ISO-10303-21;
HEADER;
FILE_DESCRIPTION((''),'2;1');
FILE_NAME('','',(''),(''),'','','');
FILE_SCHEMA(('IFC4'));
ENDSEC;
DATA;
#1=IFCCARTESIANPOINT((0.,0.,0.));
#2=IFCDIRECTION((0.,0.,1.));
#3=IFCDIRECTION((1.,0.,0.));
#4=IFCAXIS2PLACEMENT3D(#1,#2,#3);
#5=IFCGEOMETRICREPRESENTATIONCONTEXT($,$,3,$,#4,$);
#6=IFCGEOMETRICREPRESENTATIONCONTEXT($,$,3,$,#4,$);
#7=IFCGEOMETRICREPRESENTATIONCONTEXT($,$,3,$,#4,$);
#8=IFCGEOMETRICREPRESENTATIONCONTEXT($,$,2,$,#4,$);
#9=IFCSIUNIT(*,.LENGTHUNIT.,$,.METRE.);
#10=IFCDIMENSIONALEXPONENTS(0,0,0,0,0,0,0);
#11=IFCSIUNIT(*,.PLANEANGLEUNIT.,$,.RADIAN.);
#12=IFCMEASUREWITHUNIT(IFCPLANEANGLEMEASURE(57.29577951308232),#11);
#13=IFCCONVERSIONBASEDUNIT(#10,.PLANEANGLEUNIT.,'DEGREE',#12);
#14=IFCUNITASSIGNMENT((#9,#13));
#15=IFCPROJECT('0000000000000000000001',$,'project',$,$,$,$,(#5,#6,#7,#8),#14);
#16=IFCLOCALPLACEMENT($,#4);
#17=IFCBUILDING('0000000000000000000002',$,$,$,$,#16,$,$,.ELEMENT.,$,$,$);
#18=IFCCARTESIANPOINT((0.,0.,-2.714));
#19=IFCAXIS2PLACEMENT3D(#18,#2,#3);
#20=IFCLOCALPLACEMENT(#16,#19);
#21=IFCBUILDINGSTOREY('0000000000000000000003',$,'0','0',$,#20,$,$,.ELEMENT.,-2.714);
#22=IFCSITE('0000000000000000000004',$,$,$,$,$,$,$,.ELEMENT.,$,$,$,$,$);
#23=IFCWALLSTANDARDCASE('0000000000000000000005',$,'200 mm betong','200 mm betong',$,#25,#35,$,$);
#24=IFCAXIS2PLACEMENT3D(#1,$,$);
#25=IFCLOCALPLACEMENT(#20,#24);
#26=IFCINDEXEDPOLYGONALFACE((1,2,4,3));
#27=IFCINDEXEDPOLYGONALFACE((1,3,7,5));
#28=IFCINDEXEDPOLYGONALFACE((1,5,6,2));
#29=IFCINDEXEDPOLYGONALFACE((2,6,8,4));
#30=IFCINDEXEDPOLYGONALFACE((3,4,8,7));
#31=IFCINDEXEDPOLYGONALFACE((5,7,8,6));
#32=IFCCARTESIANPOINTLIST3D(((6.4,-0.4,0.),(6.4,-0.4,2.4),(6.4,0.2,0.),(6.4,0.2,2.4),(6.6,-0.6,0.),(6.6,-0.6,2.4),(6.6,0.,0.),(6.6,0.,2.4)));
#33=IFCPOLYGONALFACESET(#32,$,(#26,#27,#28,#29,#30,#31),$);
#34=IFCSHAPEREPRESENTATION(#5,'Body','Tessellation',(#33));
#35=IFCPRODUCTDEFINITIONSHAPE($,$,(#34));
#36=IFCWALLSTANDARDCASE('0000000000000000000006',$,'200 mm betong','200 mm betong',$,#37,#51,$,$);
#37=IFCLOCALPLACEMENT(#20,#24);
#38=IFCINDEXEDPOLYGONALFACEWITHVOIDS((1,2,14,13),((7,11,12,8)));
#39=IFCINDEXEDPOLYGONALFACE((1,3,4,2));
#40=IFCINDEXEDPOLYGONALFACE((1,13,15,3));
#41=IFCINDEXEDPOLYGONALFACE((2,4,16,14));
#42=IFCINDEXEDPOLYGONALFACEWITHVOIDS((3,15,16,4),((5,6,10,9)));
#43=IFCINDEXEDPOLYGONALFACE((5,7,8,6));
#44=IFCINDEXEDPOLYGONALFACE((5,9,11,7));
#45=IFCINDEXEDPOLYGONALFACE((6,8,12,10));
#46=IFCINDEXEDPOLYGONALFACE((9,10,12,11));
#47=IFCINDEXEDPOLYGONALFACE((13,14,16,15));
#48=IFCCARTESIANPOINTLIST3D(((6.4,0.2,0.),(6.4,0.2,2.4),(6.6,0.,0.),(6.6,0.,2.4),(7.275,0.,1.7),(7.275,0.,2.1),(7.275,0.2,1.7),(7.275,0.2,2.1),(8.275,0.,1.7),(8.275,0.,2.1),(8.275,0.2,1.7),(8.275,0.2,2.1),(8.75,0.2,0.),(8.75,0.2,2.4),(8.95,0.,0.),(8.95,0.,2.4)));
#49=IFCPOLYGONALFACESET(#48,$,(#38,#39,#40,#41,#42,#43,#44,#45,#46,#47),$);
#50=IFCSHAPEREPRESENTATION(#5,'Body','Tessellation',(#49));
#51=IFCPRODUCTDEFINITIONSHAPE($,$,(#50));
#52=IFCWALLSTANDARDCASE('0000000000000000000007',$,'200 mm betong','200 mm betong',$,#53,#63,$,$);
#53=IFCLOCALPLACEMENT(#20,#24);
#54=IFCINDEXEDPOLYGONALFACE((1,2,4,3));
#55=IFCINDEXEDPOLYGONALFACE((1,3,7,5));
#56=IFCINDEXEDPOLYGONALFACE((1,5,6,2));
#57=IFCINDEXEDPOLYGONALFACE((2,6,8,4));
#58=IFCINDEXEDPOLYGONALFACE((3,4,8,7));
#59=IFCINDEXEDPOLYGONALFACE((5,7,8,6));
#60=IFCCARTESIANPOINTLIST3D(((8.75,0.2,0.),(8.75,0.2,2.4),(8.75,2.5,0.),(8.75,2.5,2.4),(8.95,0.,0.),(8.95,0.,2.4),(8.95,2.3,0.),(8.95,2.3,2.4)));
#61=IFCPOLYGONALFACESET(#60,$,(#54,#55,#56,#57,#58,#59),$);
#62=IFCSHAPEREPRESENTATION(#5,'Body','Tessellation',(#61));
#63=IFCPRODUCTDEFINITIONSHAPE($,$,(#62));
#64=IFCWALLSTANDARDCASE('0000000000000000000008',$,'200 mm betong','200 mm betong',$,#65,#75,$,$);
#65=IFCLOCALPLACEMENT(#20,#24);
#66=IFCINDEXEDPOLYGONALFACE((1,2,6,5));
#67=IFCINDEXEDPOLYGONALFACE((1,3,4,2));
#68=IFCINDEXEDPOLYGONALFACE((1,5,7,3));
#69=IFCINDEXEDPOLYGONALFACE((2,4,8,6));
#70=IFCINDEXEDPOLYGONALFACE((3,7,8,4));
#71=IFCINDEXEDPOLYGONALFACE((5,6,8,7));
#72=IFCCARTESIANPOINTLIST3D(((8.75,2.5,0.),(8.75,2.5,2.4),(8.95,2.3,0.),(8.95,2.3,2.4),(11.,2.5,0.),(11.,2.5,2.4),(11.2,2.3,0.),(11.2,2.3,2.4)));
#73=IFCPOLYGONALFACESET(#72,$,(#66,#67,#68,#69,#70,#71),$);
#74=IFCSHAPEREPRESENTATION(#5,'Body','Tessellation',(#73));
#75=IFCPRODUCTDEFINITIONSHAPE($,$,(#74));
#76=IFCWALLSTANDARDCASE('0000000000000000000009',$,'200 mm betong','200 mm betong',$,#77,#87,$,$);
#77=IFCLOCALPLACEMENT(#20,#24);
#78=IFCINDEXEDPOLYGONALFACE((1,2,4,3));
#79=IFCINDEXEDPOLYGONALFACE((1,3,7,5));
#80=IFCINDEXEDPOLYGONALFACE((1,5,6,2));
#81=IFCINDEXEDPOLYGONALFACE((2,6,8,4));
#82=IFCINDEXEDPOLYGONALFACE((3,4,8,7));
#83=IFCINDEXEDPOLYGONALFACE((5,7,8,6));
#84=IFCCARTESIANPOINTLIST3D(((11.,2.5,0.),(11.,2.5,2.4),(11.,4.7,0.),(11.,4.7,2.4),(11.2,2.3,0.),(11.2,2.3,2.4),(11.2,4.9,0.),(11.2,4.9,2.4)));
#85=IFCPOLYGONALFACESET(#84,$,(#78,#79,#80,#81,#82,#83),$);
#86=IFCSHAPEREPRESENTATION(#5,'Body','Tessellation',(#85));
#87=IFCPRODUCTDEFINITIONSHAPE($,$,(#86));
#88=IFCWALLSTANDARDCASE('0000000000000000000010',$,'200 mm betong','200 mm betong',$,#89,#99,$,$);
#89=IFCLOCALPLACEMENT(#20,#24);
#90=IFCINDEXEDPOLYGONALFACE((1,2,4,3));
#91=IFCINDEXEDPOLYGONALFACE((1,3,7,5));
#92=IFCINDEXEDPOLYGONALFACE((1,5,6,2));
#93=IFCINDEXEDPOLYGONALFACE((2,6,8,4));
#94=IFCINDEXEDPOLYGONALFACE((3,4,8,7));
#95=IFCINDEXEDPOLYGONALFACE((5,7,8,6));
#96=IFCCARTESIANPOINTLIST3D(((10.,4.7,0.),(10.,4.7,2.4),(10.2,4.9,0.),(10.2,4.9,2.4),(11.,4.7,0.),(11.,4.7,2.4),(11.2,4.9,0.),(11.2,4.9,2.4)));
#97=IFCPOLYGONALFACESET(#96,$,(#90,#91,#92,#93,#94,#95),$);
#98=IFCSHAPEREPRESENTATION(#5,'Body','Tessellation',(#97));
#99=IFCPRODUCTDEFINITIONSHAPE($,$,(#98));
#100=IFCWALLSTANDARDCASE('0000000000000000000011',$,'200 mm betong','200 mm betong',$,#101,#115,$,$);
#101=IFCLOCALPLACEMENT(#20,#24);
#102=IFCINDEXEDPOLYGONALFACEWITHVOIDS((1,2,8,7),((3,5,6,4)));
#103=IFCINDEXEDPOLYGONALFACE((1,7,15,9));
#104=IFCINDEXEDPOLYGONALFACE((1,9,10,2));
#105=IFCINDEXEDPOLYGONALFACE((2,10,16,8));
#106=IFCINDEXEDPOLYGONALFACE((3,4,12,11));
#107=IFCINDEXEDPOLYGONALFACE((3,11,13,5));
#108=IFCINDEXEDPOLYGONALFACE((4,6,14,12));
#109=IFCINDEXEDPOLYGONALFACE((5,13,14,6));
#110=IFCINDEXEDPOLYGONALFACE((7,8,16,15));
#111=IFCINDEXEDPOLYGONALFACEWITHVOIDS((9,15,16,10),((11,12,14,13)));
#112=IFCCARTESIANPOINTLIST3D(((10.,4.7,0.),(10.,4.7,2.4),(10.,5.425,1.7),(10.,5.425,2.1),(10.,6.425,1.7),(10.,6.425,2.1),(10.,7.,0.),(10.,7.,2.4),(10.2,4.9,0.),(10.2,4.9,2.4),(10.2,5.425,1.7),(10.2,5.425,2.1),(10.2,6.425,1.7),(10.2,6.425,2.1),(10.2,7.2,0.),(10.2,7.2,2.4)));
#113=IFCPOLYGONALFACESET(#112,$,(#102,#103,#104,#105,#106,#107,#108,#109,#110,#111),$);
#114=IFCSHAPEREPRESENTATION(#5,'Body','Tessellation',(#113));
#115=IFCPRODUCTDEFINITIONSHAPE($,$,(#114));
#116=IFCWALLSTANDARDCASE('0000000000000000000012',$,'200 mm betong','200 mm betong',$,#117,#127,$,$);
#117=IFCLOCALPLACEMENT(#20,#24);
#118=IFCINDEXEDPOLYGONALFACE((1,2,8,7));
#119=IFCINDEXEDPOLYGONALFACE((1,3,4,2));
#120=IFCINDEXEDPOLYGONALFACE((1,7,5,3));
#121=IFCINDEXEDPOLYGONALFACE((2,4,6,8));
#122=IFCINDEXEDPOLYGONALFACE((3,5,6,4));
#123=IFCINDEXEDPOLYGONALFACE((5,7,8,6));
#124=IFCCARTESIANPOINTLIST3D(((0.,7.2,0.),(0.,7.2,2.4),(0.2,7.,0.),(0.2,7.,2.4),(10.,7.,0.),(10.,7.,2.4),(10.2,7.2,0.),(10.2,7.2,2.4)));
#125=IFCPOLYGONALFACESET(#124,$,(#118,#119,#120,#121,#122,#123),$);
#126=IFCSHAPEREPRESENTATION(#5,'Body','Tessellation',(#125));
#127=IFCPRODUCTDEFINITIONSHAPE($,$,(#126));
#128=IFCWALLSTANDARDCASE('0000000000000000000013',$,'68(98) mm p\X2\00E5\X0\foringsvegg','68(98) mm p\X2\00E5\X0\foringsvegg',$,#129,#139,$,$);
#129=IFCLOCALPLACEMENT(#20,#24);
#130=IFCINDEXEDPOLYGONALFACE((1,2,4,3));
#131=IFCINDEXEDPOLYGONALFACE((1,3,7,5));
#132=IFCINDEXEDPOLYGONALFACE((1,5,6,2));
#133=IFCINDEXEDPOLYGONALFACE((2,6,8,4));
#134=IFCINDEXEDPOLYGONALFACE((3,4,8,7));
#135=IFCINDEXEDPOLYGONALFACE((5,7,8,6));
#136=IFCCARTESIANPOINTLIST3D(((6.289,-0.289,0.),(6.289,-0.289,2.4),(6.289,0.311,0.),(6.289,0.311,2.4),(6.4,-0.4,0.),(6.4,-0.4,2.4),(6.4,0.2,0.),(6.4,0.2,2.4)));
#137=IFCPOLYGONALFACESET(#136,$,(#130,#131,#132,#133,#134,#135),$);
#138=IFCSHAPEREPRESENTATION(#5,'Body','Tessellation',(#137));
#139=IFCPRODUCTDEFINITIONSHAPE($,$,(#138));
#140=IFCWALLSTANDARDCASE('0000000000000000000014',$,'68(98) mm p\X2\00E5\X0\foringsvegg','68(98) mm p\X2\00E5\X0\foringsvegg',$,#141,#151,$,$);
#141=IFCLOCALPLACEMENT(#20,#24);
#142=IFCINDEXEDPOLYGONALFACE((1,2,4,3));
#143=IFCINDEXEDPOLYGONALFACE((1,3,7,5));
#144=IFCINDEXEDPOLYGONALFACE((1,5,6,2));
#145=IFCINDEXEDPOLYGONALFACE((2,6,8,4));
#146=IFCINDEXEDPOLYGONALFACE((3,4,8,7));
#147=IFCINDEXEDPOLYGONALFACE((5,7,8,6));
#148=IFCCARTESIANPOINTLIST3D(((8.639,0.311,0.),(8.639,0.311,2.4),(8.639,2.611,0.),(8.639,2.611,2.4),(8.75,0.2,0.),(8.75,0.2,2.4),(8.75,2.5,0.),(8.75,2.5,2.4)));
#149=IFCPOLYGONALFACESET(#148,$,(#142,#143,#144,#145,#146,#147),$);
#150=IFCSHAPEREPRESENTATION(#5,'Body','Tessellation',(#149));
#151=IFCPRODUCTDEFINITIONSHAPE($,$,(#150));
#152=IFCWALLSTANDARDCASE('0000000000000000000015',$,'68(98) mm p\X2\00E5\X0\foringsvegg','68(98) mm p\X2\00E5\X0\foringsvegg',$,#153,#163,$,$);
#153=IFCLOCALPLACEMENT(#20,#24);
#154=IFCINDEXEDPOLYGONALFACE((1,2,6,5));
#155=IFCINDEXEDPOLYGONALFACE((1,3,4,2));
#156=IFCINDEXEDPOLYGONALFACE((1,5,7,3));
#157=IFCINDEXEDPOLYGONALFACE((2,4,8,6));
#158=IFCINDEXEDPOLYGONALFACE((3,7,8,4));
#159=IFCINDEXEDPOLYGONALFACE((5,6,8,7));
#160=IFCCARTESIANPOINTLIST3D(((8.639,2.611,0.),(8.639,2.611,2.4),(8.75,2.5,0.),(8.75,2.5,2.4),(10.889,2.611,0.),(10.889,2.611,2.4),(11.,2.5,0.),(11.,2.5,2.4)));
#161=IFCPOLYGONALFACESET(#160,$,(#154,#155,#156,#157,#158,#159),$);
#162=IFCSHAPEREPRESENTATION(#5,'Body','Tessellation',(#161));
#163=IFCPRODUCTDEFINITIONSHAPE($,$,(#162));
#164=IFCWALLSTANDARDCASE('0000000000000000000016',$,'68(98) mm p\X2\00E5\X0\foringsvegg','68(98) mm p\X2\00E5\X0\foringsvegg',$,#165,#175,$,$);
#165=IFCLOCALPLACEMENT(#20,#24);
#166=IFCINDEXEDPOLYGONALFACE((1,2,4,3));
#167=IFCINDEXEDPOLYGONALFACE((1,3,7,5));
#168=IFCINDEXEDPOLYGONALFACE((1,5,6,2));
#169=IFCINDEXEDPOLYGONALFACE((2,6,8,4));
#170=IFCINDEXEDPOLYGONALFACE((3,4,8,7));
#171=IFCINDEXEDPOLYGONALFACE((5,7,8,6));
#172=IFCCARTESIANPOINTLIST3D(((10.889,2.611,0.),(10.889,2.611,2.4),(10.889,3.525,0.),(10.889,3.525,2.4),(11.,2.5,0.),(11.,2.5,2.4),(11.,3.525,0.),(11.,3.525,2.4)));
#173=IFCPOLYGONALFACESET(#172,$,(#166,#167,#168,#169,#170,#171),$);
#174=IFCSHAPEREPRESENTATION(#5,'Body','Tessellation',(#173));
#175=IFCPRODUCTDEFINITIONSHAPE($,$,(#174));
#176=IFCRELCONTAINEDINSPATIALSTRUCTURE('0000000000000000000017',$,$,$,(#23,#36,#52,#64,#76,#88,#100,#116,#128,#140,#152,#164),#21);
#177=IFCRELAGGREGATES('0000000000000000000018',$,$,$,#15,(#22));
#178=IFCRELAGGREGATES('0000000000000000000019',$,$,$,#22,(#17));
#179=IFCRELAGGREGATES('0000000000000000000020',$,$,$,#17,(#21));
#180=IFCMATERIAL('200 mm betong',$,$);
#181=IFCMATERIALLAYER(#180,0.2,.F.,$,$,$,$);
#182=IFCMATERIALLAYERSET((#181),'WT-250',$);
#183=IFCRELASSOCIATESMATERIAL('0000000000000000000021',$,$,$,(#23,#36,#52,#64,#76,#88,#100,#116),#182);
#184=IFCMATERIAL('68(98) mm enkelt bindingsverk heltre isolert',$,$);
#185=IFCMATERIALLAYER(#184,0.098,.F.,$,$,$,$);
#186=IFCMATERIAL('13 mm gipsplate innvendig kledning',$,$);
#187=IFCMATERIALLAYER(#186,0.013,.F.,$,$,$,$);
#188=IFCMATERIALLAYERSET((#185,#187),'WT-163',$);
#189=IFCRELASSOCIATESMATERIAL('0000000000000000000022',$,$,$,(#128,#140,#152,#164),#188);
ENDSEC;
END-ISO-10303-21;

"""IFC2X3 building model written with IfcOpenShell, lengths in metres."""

from ifc_helpers import new_model, entity, si_unit, converted_unit, frame, origin_with_axes, place, context, project, spatial, polyline, outline, extrude, material, layer, layer_set, layer_usage, element, save


model = new_model("IFC2X3")

# Units and contexts
context_of_model_1 = context(None, 3, world=origin_with_axes())
context_of_model_2 = context(None, 3, world=origin_with_axes())
context_of_model_3 = context(None, 3, world=origin_with_axes())
context_of_model_4 = context(None, 2, world=origin_with_axes())
ifc_project = project(units=[si_unit("LENGTHUNIT", "METRE"), converted_unit("PLANEANGLEUNIT", "DEGREE", entity("IfcPlaneAngleMeasure", 57.29577951308232), si_unit("PLANEANGLEUNIT", "RADIAN"), dimensions=[0, 0, 0, 0, 0, 0, 0])], contexts=[context_of_model_1, context_of_model_2, context_of_model_3, context_of_model_4])

# Site, building, storey
site = spatial("IfcSite", under=ifc_project, CompositionType="ELEMENT")
building_placement = place(None, origin_with_axes())
building = spatial("IfcBuilding", under=site, at=building_placement, CompositionType="ELEMENT")
storey_placement = place(building_placement, frame((0.0, 0.0, -2.714), z_axis=(0.0, 0.0, 1.0), x_axis=(1.0, 0.0, 0.0)))
storey = spatial("IfcBuildingStorey", under=building, at=storey_placement, Name="0", Description="0", CompositionType="ELEMENT", Elevation=-2.714)

# Wall
ifc_material_1 = material(Name="200 mm betong")
ifc_layer_1 = layer(ifc_material_1, 0.2, ventilated=False)
ifc_layer_set_1 = layer_set([ifc_layer_1], Name="WT-250")
ifc_layer_usage_1 = layer_usage(ifc_layer_set_1, "AXIS2", "POSITIVE", 0.0)
wall_1_placement = place(storey_placement, frame((6.6, -0.6, 0.0), z_axis=(0.0, 0.0, 1.0), x_axis=(0.0, 1.0, 0.0)))
element("IfcWallStandardCase", 1, at=wall_1_placement, inside=storey, material=ifc_layer_usage_1, Name="200 mm betong", Description="200 mm betong", context=context_of_model_1, shape_type="SweptSolid", body=[
    extrude(outline(polyline([(0.0, 0.0), (0.6, 0.0), (0.8, 0.2), (0.2, 0.2), (0.0, 0.0)])), frame((0.0, 0.0, 0.0), z_axis=(0.0, 0.0, 1.0), x_axis=(1.0, 0.0, 0.0)), (0.0, 0.0, 1.0), 2.4),
])

# Wall, opening
wall_2_placement = place(storey_placement, frame((6.6, 0.0, 0.0), z_axis=(0.0, 0.0, 1.0), x_axis=(1.0, 0.0, 0.0)))
wall_2 = element("IfcWallStandardCase", 2, at=wall_2_placement, inside=storey, material=ifc_layer_usage_1, Name="200 mm betong", Description="200 mm betong", context=context_of_model_1, shape_type="SweptSolid", body=[
    extrude(outline(polyline([(0.0, 0.0), (2.35, 0.0), (2.15, 0.2), (-0.2, 0.2), (0.0, 0.0)])), frame((0.0, 0.0, 0.0), z_axis=(0.0, 0.0, 1.0), x_axis=(1.0, 0.0, 0.0)), (0.0, 0.0, 1.0), 2.4),
])
opening_1_placement = place(wall_2_placement, frame((0.675, 0.0, 1.7), z_axis=(0.0, 0.0, 1.0), x_axis=(1.0, 0.0, 0.0)))
element("IfcOpeningElement", 3, at=opening_1_placement, inside=storey, cuts=wall_2, context=context_of_model_1, shape_type="SweptSolid", body=[
    extrude(outline(polyline([(0.0, 0.0), (0.4, 0.0), (0.4, 1.0), (0.0, 1.0), (0.0, 0.0)])), frame((0.0, 0.0, 0.0), z_axis=(0.0, 1.0, 0.0), x_axis=(0.0, 0.0, 1.0)), (0.0, 0.0, 1.0), 0.2),
])

# Walls
wall_3_placement = place(storey_placement, frame((8.95, 0.0, 0.0), z_axis=(0.0, 0.0, 1.0), x_axis=(0.0, 1.0, 0.0)))
element("IfcWallStandardCase", 4, at=wall_3_placement, inside=storey, material=ifc_layer_usage_1, Name="200 mm betong", Description="200 mm betong", context=context_of_model_1, shape_type="SweptSolid", body=[
    extrude(outline(polyline([(0.0, 0.0), (2.3, 0.0), (2.5, 0.2), (0.2, 0.2), (0.0, 0.0)])), frame((0.0, 0.0, 0.0), z_axis=(0.0, 0.0, 1.0), x_axis=(1.0, 0.0, 0.0)), (0.0, 0.0, 1.0), 2.4),
])
wall_4_placement = place(storey_placement, frame((8.95, 2.3, 0.0), z_axis=(0.0, 0.0, 1.0), x_axis=(1.0, 0.0, 0.0)))
element("IfcWallStandardCase", 5, at=wall_4_placement, inside=storey, material=ifc_layer_usage_1, Name="200 mm betong", Description="200 mm betong", context=context_of_model_1, shape_type="SweptSolid", body=[
    extrude(outline(polyline([(0.0, 0.0), (2.25, 0.0), (2.05, 0.2), (-0.2, 0.2), (0.0, 0.0)])), frame((0.0, 0.0, 0.0), z_axis=(0.0, 0.0, 1.0), x_axis=(1.0, 0.0, 0.0)), (0.0, 0.0, 1.0), 2.4),
])
wall_5_placement = place(storey_placement, frame((11.2, 2.3, 0.0), z_axis=(0.0, 0.0, 1.0), x_axis=(0.0, 1.0, 0.0)))
element("IfcWallStandardCase", 6, at=wall_5_placement, inside=storey, material=ifc_layer_usage_1, Name="200 mm betong", Description="200 mm betong", context=context_of_model_1, shape_type="SweptSolid", body=[
    extrude(outline(polyline([(0.0, 0.0), (2.6, 0.0), (2.4, 0.2), (0.2, 0.2), (0.0, 0.0)])), frame((0.0, 0.0, 0.0), z_axis=(0.0, 0.0, 1.0), x_axis=(1.0, 0.0, 0.0)), (0.0, 0.0, 1.0), 2.4),
])
wall_6_placement = place(storey_placement, frame((11.2, 4.9, 0.0), z_axis=(0.0, 0.0, 1.0), x_axis=(-1.0, 0.0, 0.0)))
element("IfcWallStandardCase", 7, at=wall_6_placement, inside=storey, material=ifc_layer_usage_1, Name="200 mm betong", Description="200 mm betong", context=context_of_model_1, shape_type="SweptSolid", body=[
    extrude(outline(polyline([(0.0, 0.0), (1.0, 0.0), (1.2, 0.2), (0.2, 0.2), (0.0, 0.0)])), frame((0.0, 0.0, 0.0), z_axis=(0.0, 0.0, 1.0), x_axis=(1.0, 0.0, 0.0)), (0.0, 0.0, 1.0), 2.4),
])

# Wall, opening
wall_7_placement = place(storey_placement, frame((10.2, 4.9, 0.0), z_axis=(0.0, 0.0, 1.0), x_axis=(0.0, 1.0, 0.0)))
wall_7 = element("IfcWallStandardCase", 8, at=wall_7_placement, inside=storey, material=ifc_layer_usage_1, Name="200 mm betong", Description="200 mm betong", context=context_of_model_1, shape_type="SweptSolid", body=[
    extrude(outline(polyline([(0.0, 0.0), (2.3, 0.0), (2.1, 0.2), (-0.2, 0.2), (0.0, 0.0)])), frame((0.0, 0.0, 0.0), z_axis=(0.0, 0.0, 1.0), x_axis=(1.0, 0.0, 0.0)), (0.0, 0.0, 1.0), 2.4),
])
opening_2_placement = place(wall_7_placement, frame((0.525, 0.0, 1.7), z_axis=(0.0, 0.0, 1.0), x_axis=(1.0, 0.0, 0.0)))
element("IfcOpeningElement", 9, at=opening_2_placement, inside=storey, cuts=wall_7, context=context_of_model_1, shape_type="SweptSolid", body=[
    extrude(outline(polyline([(0.0, 0.0), (0.4, 0.0), (0.4, 1.0), (0.0, 1.0), (0.0, 0.0)])), frame((0.0, 0.0, 0.0), z_axis=(0.0, 1.0, 0.0), x_axis=(0.0, 0.0, 1.0)), (0.0, 0.0, 1.0), 0.2),
])

# Walls
wall_8_placement = place(storey_placement, frame((10.2, 7.2, 0.0), z_axis=(0.0, 0.0, 1.0), x_axis=(-1.0, 0.0, 0.0)))
element("IfcWallStandardCase", 10, at=wall_8_placement, inside=storey, material=ifc_layer_usage_1, Name="200 mm betong", Description="200 mm betong", context=context_of_model_1, shape_type="SweptSolid", body=[
    extrude(outline(polyline([(0.0, 0.0), (10.2, 0.0), (10.0, 0.2), (0.2, 0.2), (0.0, 0.0)])), frame((0.0, 0.0, 0.0), z_axis=(0.0, 0.0, 1.0), x_axis=(1.0, 0.0, 0.0)), (0.0, 0.0, 1.0), 2.4),
])
ifc_material_2 = material(Name="68(98) mm enkelt bindingsverk heltre isolert")
ifc_layer_2 = layer(ifc_material_2, 0.098, ventilated=False)
ifc_material_3 = material(Name="13 mm gipsplate innvendig kledning")
ifc_layer_3 = layer(ifc_material_3, 0.013, ventilated=False)
ifc_layer_set_2 = layer_set([ifc_layer_2, ifc_layer_3], Name="WT-163")
ifc_layer_usage_2 = layer_usage(ifc_layer_set_2, "AXIS2", "POSITIVE", 0.0)
wall_9_placement = place(storey_placement, frame((6.4, -0.4, 0.0), z_axis=(0.0, 0.0, 1.0), x_axis=(0.0, 1.0, 0.0)))
element("IfcWallStandardCase", 11, at=wall_9_placement, inside=storey, material=ifc_layer_usage_2, Name="68(98) mm påforingsvegg", Description="68(98) mm påforingsvegg", context=context_of_model_1, shape_type="SweptSolid", body=[
    extrude(outline(polyline([(0.0, 0.0), (0.6, 0.0), (0.711, 0.111), (0.111, 0.111), (0.0, 0.0)])), frame((0.0, 0.0, 0.0), z_axis=(0.0, 0.0, 1.0), x_axis=(1.0, 0.000001, 0.0)), (0.0, 0.0, 1.0), 2.4),
])
wall_10_placement = place(storey_placement, frame((8.75, 0.2, 0.0), z_axis=(0.0, 0.0, 1.0), x_axis=(0.0, 1.0, 0.0)))
element("IfcWallStandardCase", 12, at=wall_10_placement, inside=storey, material=ifc_layer_usage_2, Name="68(98) mm påforingsvegg", Description="68(98) mm påforingsvegg", context=context_of_model_1, shape_type="SweptSolid", body=[
    extrude(outline(polyline([(0.0, 0.0), (2.3, 0.0), (2.411, 0.111), (0.111, 0.111), (0.0, 0.0)])), frame((0.0, 0.0, 0.0), z_axis=(0.0, 0.0, 1.0), x_axis=(1.0, -0.000001, 0.0)), (0.0, 0.0, 1.0), 2.4),
])
wall_11_placement = place(storey_placement, frame((8.75, 2.5, 0.0), z_axis=(0.0, 0.0, 1.0), x_axis=(1.0, 0.0, 0.0)))
element("IfcWallStandardCase", 13, at=wall_11_placement, inside=storey, material=ifc_layer_usage_2, Name="68(98) mm påforingsvegg", Description="68(98) mm påforingsvegg", context=context_of_model_1, shape_type="SweptSolid", body=[
    extrude(outline(polyline([(0.0, 0.0), (2.25, 0.0), (2.139, 0.111), (-0.111, 0.111), (0.0, 0.0)])), origin_with_axes(), (0.0, 0.0, 1.0), 2.4),
])
wall_12_placement = place(storey_placement, frame((11.0, 2.5, 0.0), z_axis=(0.0, 0.0, 1.0), x_axis=(0.0, 1.0, 0.0)))
element("IfcWallStandardCase", 14, at=wall_12_placement, inside=storey, material=ifc_layer_usage_2, Name="68(98) mm påforingsvegg", Description="68(98) mm påforingsvegg", context=context_of_model_1, shape_type="SweptSolid", body=[
    extrude(outline(polyline([(0.0, 0.0), (1.025, 0.0), (1.025, 0.111), (0.111, 0.111), (0.0, 0.0)])), frame((0.0, 0.0, 0.0), z_axis=(0.0, 0.0, 1.0), x_axis=(1.0, -0.000002, 0.0)), (0.0, 0.0, 1.0), 2.4),
])

save(model, "model.ifc")
